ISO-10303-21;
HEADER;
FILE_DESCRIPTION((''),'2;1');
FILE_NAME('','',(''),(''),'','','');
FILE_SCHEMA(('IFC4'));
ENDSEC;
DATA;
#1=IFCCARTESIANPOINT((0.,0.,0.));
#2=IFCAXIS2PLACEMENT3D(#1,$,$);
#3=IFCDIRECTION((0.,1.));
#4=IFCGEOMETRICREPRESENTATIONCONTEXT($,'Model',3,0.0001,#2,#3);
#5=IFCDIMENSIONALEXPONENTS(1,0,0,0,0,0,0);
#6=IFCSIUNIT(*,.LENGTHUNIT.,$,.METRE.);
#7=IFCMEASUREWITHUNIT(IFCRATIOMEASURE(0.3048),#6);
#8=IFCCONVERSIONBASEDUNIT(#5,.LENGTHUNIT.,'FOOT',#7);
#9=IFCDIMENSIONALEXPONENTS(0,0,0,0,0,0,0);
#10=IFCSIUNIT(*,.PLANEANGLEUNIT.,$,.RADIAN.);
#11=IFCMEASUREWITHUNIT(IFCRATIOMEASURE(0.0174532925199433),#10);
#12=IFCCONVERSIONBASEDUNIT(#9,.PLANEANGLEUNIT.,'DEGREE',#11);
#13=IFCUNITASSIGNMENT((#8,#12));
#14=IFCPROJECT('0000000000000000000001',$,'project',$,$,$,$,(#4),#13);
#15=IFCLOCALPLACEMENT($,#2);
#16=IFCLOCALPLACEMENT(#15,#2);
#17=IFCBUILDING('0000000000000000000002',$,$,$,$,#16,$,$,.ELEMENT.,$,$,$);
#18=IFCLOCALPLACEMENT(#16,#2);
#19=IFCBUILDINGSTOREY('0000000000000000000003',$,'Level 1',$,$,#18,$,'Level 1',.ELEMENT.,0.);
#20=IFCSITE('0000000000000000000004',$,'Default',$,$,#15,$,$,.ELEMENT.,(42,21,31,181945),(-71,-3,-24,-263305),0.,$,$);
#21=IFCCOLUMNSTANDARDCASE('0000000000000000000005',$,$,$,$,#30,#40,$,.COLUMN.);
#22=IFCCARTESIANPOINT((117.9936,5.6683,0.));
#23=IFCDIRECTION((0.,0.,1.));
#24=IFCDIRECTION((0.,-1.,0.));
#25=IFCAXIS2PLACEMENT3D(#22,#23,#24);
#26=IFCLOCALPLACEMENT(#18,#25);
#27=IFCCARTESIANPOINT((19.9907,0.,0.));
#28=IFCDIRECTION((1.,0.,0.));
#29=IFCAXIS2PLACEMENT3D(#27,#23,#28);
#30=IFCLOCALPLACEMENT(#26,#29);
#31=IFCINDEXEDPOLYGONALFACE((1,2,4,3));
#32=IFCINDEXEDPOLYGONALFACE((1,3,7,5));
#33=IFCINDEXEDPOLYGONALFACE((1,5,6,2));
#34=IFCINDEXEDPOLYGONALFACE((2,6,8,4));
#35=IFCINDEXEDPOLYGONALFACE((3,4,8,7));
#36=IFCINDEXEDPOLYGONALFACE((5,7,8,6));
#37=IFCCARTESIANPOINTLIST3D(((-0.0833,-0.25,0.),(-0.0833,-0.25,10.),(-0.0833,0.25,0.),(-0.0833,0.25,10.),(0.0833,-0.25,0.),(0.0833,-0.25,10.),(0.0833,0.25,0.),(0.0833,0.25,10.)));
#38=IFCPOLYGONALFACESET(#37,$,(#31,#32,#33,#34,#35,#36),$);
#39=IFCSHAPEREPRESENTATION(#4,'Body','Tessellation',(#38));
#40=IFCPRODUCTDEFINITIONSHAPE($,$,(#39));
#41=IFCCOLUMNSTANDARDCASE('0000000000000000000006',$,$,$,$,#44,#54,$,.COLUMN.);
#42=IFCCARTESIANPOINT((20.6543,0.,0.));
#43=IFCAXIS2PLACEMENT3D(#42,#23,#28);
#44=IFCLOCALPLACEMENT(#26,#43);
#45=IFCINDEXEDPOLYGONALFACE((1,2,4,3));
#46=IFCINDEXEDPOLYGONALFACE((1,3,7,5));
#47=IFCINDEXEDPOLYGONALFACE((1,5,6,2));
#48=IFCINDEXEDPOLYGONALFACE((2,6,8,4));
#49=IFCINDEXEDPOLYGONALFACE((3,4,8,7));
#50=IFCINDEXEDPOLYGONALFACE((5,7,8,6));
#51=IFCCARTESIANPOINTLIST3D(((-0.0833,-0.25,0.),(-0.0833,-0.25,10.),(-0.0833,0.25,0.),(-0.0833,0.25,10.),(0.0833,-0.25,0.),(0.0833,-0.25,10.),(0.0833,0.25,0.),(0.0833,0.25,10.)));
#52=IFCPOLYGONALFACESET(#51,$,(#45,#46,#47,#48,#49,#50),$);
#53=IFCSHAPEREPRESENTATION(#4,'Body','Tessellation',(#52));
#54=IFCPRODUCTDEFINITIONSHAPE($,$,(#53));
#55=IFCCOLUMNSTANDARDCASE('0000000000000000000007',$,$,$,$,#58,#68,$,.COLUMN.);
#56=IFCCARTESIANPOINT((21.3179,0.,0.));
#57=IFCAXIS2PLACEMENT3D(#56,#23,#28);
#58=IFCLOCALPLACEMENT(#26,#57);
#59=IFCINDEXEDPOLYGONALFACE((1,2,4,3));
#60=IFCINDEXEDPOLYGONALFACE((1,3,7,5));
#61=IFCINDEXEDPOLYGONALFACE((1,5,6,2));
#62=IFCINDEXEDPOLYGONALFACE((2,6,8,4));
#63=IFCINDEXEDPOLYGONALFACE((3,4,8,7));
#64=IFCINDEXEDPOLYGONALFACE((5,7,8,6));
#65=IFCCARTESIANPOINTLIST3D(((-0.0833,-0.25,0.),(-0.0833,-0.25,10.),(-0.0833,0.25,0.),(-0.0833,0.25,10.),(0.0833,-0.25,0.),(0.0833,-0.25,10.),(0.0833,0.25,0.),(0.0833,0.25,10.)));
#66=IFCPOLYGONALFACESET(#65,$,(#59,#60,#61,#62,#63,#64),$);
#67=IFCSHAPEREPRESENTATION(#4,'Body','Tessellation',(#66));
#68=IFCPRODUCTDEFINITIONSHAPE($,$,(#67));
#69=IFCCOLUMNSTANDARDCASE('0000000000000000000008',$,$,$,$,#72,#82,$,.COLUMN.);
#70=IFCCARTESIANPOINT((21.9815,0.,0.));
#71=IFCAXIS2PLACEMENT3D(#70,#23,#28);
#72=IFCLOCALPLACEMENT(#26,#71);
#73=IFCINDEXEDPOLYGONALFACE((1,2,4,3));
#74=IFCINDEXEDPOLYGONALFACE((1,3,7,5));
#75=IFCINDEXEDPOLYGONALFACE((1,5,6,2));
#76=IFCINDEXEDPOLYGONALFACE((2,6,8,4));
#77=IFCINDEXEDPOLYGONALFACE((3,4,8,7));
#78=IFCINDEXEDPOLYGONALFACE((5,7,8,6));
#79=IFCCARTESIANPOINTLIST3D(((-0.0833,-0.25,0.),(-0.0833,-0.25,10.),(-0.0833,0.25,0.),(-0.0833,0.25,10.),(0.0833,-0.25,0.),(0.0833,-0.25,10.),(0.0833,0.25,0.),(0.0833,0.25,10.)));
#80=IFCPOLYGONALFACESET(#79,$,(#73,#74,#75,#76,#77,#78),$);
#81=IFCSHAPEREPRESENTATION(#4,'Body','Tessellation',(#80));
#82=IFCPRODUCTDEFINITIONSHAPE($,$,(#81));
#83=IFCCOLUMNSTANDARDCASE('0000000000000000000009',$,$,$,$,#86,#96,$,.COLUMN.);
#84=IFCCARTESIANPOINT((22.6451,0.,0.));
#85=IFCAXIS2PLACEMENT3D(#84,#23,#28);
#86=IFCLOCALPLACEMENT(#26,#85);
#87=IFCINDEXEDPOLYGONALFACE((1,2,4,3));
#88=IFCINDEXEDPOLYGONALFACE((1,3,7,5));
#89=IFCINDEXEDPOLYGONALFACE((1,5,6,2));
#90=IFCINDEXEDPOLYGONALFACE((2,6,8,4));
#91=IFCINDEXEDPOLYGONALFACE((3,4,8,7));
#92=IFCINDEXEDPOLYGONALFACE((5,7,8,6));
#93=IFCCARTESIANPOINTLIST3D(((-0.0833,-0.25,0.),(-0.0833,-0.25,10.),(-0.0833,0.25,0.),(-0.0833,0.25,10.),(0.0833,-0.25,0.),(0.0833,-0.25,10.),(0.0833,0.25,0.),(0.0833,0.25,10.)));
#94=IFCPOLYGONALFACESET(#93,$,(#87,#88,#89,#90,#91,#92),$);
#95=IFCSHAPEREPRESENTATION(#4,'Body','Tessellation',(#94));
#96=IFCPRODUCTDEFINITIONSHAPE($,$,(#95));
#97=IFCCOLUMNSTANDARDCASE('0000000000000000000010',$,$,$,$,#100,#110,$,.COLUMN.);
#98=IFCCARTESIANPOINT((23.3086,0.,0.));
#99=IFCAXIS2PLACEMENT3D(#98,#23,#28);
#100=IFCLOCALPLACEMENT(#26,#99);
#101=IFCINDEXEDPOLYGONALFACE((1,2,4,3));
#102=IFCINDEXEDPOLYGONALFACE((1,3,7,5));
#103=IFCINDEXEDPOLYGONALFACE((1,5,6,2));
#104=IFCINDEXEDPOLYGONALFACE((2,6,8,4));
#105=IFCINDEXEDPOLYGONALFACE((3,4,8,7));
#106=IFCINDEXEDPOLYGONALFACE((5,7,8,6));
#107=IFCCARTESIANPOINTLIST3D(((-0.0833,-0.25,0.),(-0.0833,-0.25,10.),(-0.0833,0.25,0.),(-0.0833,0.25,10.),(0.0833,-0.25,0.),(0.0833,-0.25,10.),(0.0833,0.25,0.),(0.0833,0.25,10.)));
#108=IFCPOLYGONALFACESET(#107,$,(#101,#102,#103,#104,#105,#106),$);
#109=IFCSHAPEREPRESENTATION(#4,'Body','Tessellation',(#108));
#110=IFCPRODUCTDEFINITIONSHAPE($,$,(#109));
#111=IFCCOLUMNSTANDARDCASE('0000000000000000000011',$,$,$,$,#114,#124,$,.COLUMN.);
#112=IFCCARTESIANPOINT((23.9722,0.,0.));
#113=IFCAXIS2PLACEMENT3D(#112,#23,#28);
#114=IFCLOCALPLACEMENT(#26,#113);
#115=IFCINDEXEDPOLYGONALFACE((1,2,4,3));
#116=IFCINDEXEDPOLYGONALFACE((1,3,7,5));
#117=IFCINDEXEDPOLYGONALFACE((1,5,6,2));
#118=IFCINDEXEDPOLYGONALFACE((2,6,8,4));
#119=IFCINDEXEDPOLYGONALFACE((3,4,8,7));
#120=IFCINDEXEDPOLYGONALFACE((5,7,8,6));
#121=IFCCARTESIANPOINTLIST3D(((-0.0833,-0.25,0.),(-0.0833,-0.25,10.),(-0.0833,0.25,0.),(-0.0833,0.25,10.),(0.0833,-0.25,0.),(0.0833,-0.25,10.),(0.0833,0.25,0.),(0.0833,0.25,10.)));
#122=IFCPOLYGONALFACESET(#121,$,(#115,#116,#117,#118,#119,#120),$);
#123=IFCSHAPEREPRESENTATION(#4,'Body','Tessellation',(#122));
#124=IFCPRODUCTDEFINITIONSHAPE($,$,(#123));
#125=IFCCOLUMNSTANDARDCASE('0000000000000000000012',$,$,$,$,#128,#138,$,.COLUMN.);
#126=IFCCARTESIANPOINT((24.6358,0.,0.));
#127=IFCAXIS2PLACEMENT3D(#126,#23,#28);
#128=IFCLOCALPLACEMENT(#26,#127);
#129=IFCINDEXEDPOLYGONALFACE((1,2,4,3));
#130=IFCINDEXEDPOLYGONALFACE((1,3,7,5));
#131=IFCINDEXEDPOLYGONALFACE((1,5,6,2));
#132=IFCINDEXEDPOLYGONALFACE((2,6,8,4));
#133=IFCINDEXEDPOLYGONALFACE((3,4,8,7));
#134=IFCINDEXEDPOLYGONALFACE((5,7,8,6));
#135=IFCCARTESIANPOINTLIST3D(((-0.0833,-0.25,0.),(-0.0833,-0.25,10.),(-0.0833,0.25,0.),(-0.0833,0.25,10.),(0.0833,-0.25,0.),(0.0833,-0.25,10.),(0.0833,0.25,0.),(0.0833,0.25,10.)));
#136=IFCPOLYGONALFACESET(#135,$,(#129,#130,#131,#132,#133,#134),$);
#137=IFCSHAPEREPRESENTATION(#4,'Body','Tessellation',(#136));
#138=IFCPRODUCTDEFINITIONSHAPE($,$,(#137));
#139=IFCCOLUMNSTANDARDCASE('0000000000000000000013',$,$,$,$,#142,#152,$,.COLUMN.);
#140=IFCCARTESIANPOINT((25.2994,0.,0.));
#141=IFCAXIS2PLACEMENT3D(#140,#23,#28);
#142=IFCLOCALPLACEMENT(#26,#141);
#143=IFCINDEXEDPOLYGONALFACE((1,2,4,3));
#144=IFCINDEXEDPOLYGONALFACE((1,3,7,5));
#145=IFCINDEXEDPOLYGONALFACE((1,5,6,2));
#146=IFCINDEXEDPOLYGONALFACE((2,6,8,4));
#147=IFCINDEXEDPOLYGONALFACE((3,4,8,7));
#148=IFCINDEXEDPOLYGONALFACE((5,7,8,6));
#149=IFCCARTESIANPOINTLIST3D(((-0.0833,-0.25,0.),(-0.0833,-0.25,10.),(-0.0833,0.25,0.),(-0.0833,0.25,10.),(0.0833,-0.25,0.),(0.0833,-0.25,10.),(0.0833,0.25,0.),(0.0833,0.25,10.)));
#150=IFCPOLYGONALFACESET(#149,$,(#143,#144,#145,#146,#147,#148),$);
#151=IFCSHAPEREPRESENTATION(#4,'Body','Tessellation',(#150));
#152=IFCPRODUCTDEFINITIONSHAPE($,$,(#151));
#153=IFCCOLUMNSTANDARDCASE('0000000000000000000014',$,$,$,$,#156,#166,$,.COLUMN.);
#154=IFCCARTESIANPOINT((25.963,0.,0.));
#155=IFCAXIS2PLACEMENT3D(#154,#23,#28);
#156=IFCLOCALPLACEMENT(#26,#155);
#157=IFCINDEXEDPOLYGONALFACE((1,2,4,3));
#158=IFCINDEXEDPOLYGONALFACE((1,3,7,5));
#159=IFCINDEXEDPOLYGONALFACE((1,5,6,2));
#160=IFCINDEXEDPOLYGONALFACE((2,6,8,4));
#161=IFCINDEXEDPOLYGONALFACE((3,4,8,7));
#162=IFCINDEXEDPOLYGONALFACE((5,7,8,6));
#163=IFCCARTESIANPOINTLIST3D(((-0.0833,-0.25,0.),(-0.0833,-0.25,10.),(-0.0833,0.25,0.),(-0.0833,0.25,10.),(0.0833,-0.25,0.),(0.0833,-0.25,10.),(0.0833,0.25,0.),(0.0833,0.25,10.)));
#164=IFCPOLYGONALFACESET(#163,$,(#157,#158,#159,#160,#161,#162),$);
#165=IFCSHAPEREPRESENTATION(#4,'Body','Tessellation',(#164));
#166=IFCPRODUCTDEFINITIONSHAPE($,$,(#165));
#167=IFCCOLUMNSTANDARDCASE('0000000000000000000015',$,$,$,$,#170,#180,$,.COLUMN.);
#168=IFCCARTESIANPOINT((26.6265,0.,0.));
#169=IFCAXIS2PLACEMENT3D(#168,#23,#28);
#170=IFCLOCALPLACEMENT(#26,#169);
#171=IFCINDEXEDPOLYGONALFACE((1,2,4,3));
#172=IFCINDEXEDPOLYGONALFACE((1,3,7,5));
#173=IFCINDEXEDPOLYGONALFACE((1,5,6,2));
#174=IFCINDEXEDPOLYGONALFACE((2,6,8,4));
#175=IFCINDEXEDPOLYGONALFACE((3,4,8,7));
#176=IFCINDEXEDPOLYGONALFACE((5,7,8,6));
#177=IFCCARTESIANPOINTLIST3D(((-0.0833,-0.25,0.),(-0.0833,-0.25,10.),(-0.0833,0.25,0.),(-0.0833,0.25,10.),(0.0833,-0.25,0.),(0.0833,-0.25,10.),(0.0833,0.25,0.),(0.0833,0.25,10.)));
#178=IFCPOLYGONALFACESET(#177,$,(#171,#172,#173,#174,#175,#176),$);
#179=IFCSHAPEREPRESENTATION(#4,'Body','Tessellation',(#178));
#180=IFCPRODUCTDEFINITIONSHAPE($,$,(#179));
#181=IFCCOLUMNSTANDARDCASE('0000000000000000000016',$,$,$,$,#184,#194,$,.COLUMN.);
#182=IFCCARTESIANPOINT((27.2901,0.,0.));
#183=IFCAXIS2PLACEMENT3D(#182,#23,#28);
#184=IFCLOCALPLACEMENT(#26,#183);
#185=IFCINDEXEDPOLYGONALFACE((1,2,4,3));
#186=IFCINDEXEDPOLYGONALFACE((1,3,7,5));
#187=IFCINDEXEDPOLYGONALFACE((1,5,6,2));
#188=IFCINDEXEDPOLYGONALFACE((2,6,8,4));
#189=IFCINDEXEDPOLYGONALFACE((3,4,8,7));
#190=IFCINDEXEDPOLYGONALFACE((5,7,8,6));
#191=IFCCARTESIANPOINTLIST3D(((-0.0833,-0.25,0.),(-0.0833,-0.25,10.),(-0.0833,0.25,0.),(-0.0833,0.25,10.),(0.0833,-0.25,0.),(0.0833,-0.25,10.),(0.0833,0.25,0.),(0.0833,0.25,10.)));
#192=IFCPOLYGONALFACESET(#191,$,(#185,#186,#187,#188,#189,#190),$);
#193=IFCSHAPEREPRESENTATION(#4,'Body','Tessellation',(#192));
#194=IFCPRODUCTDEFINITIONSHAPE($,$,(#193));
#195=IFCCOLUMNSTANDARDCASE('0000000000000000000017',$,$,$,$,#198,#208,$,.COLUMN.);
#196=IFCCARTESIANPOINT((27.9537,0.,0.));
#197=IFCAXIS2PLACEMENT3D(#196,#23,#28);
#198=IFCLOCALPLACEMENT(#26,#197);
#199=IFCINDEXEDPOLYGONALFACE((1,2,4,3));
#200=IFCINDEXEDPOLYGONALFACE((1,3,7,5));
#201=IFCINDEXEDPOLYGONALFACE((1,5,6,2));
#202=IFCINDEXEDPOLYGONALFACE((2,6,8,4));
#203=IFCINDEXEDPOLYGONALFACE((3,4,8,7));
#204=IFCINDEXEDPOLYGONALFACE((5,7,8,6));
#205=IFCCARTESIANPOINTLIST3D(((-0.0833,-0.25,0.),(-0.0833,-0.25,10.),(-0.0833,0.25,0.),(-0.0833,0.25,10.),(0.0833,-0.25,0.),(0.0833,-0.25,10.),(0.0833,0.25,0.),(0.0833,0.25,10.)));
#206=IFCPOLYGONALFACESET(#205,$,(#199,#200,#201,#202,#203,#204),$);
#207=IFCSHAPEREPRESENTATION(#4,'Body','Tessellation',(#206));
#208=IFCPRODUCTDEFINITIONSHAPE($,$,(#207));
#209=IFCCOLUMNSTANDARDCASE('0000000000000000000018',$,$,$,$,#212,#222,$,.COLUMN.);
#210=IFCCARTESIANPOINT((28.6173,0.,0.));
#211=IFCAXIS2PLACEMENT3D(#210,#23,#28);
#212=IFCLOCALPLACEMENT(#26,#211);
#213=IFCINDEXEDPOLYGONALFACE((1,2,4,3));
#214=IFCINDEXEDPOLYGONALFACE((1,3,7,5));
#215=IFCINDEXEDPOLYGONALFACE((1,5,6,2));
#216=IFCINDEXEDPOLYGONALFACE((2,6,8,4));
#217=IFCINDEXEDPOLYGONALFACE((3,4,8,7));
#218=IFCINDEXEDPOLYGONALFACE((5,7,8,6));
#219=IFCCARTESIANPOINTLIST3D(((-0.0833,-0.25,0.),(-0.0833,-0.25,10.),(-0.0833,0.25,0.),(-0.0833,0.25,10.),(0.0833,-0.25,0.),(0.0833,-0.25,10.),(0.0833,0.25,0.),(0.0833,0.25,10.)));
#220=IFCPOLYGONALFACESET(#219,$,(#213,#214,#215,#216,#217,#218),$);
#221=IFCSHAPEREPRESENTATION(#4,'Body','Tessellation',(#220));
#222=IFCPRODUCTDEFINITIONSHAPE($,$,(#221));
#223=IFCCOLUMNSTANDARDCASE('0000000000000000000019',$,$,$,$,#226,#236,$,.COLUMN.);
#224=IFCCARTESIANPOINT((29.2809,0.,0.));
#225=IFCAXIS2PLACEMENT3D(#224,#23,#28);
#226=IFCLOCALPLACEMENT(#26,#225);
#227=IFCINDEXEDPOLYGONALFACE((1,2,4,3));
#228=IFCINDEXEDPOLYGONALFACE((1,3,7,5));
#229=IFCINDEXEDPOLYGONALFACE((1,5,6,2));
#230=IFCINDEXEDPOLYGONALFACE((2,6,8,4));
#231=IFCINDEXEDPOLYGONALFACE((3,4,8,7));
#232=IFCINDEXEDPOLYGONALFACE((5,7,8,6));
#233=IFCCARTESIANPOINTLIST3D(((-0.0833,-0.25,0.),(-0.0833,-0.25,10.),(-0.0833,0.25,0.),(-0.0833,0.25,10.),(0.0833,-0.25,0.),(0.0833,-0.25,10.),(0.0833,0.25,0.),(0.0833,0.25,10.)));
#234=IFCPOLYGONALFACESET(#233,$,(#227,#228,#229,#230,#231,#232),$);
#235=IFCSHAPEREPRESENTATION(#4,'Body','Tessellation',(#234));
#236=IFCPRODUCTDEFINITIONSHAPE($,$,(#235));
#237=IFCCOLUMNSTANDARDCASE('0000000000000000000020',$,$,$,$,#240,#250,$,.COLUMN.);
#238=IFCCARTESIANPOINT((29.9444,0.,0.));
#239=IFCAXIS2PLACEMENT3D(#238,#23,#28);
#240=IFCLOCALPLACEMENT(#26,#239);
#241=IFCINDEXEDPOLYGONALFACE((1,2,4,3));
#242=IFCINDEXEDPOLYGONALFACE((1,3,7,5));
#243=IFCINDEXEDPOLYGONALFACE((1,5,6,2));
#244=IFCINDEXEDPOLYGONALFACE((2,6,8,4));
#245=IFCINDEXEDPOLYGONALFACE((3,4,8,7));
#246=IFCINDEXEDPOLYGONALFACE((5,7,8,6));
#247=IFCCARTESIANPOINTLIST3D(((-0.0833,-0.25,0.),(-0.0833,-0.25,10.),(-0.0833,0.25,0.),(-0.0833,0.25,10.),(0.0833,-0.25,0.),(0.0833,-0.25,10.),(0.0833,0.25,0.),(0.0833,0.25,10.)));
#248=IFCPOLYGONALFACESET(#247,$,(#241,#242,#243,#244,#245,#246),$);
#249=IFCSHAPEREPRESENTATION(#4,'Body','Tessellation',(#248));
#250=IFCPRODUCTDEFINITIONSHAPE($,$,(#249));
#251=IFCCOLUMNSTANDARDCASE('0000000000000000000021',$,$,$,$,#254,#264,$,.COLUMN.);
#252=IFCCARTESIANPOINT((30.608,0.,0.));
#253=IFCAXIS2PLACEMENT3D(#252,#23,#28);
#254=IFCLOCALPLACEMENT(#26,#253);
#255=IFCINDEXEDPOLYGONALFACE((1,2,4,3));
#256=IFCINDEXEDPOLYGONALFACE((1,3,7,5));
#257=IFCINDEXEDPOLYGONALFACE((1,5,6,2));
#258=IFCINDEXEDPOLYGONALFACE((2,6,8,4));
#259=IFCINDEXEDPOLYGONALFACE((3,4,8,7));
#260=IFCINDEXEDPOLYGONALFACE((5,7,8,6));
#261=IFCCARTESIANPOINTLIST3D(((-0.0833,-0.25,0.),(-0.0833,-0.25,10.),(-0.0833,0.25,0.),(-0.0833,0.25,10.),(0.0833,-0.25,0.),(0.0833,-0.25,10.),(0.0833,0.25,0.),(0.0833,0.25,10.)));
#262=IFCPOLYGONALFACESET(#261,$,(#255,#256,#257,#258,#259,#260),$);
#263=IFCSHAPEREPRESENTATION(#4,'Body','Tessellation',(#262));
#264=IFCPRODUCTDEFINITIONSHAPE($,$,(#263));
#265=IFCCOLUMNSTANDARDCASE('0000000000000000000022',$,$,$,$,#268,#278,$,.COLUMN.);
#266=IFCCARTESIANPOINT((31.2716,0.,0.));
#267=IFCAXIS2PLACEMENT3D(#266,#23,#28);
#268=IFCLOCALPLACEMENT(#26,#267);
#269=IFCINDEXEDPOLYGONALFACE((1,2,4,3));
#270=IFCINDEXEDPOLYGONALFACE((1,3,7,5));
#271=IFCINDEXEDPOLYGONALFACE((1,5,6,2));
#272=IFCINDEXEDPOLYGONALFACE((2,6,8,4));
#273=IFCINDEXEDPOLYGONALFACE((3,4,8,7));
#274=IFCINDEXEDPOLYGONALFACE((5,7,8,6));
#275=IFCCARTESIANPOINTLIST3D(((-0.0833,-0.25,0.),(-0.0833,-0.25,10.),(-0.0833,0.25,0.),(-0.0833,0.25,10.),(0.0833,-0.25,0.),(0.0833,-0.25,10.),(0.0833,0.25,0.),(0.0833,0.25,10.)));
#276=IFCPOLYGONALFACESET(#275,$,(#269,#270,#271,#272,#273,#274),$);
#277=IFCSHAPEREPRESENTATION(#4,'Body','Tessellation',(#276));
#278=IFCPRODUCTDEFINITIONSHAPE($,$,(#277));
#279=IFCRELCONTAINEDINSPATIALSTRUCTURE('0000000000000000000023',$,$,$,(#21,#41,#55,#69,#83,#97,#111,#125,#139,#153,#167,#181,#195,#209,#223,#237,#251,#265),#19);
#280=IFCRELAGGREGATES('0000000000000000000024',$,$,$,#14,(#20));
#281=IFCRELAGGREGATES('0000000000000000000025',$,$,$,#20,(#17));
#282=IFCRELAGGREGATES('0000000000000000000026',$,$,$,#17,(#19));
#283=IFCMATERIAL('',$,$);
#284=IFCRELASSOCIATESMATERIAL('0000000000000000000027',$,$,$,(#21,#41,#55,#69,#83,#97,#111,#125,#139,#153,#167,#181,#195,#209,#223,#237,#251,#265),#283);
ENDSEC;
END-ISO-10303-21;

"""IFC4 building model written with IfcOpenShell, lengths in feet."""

from ifc_helpers import new_model, entity, si_unit, converted_unit, direction, frame, origin, place, context, project, spatial, rectangle, extrude, material, element, save


model = new_model("IFC4")

# Units and contexts
model_context = context("Model", 3, precision=0.0001, world=origin(), true_north=direction((0.0, 1.0)))
ifc_project = project(units=[converted_unit("LENGTHUNIT", "FOOT", entity("IfcRatioMeasure", 0.3048), si_unit("LENGTHUNIT", "METRE"), dimensions=[1, 0, 0, 0, 0, 0, 0]), converted_unit("PLANEANGLEUNIT", "DEGREE", entity("IfcRatioMeasure", 0.0174532925199433), si_unit("PLANEANGLEUNIT", "RADIAN"), dimensions=[0, 0, 0, 0, 0, 0, 0])], contexts=[model_context])

# Site, building, storey
site_placement = place(None, origin())
site = spatial("IfcSite", under=ifc_project, at=site_placement, Name="Default", CompositionType="ELEMENT", RefLatitude=(42, 21, 31, 181945), RefLongitude=(-71, -3, -24, -263305), RefElevation=0.0)
building_placement = place(site_placement, origin())
building = spatial("IfcBuilding", under=site, at=building_placement, CompositionType="ELEMENT")
storey_placement = place(building_placement, origin())
storey = spatial("IfcBuildingStorey", under=building, at=storey_placement, Name="Level 1", LongName="Level 1", CompositionType="ELEMENT", Elevation=0.0)

# Columns
ifc_material = material(Name="")
placement = place(storey_placement, frame((117.9936, 5.6683, 0.0), z_axis=(0.0, 0.0, 1.0), x_axis=(0.0, -1.0, 0.0)))
for number, where, z_axis, x_axis in (
    (1, (19.9907, 0.0, 0.0), (0.0, 0.0, 1.0), (1.0, 0.0, 0.0)),
    (2, (20.6543, 0.0, 0.0), (0.0, 0.0, 1.0), (1.0, 0.0, 0.0)),
    (3, (21.3179, 0.0, 0.0), (0.0, 0.0, 1.0), (1.0, 0.0, 0.0)),
    (4, (21.9815, 0.0, 0.0), (0.0, 0.0, 1.0), (1.0, 0.0, 0.0)),
    (5, (22.6451, 0.0, 0.0), (0.0, 0.0, 1.0), (1.0, 0.0, 0.0)),
    (6, (23.3086, 0.0, 0.0), (0.0, 0.0, 1.0), (1.0, 0.0, 0.0)),
    (7, (23.9722, 0.0, 0.0), (0.0, 0.0, 1.0), (1.0, 0.0, 0.0)),
    (8, (24.6358, 0.0, 0.0), (0.0, 0.0, 1.0), (1.0, 0.0, 0.0)),
    (9, (25.2994, 0.0, 0.0), (0.0, 0.0, 1.0), (1.0, 0.0, 0.0)),
    (10, (25.963, 0.0, 0.0), (0.0, 0.0, 1.0), (1.0, 0.0, 0.0)),
    (11, (26.6265, 0.0, 0.0), (0.0, 0.0, 1.0), (1.0, 0.0, 0.0)),
    (12, (27.2901, 0.0, 0.0), (0.0, 0.0, 1.0), (1.0, 0.0, 0.0)),
    (13, (27.9537, 0.0, 0.0), (0.0, 0.0, 1.0), (1.0, 0.0, 0.0)),
    (14, (28.6173, 0.0, 0.0), (0.0, 0.0, 1.0), (1.0, 0.0, 0.0)),
    (15, (29.2809, 0.0, 0.0), (0.0, 0.0, 1.0), (1.0, 0.0, 0.0)),
    (16, (29.9444, 0.0, 0.0), (0.0, 0.0, 1.0), (1.0, 0.0, 0.0)),
    (17, (30.608, 0.0, 0.0), (0.0, 0.0, 1.0), (1.0, 0.0, 0.0)),
    (18, (31.2716, 0.0, 0.0), (0.0, 0.0, 1.0), (1.0, 0.0, 0.0)),
):
    element("IfcColumnStandardCase", number, at=place(placement, frame(where, z_axis=z_axis, x_axis=x_axis)), inside=storey, material=ifc_material, PredefinedType="COLUMN", context=model_context, shape_type="SweptSolid", body=[
        extrude(rectangle(XDim=0.1667, YDim=0.5), origin(), (0.0, 0.0, 1.0), 10.0),
    ])

save(model, "model.ifc")
